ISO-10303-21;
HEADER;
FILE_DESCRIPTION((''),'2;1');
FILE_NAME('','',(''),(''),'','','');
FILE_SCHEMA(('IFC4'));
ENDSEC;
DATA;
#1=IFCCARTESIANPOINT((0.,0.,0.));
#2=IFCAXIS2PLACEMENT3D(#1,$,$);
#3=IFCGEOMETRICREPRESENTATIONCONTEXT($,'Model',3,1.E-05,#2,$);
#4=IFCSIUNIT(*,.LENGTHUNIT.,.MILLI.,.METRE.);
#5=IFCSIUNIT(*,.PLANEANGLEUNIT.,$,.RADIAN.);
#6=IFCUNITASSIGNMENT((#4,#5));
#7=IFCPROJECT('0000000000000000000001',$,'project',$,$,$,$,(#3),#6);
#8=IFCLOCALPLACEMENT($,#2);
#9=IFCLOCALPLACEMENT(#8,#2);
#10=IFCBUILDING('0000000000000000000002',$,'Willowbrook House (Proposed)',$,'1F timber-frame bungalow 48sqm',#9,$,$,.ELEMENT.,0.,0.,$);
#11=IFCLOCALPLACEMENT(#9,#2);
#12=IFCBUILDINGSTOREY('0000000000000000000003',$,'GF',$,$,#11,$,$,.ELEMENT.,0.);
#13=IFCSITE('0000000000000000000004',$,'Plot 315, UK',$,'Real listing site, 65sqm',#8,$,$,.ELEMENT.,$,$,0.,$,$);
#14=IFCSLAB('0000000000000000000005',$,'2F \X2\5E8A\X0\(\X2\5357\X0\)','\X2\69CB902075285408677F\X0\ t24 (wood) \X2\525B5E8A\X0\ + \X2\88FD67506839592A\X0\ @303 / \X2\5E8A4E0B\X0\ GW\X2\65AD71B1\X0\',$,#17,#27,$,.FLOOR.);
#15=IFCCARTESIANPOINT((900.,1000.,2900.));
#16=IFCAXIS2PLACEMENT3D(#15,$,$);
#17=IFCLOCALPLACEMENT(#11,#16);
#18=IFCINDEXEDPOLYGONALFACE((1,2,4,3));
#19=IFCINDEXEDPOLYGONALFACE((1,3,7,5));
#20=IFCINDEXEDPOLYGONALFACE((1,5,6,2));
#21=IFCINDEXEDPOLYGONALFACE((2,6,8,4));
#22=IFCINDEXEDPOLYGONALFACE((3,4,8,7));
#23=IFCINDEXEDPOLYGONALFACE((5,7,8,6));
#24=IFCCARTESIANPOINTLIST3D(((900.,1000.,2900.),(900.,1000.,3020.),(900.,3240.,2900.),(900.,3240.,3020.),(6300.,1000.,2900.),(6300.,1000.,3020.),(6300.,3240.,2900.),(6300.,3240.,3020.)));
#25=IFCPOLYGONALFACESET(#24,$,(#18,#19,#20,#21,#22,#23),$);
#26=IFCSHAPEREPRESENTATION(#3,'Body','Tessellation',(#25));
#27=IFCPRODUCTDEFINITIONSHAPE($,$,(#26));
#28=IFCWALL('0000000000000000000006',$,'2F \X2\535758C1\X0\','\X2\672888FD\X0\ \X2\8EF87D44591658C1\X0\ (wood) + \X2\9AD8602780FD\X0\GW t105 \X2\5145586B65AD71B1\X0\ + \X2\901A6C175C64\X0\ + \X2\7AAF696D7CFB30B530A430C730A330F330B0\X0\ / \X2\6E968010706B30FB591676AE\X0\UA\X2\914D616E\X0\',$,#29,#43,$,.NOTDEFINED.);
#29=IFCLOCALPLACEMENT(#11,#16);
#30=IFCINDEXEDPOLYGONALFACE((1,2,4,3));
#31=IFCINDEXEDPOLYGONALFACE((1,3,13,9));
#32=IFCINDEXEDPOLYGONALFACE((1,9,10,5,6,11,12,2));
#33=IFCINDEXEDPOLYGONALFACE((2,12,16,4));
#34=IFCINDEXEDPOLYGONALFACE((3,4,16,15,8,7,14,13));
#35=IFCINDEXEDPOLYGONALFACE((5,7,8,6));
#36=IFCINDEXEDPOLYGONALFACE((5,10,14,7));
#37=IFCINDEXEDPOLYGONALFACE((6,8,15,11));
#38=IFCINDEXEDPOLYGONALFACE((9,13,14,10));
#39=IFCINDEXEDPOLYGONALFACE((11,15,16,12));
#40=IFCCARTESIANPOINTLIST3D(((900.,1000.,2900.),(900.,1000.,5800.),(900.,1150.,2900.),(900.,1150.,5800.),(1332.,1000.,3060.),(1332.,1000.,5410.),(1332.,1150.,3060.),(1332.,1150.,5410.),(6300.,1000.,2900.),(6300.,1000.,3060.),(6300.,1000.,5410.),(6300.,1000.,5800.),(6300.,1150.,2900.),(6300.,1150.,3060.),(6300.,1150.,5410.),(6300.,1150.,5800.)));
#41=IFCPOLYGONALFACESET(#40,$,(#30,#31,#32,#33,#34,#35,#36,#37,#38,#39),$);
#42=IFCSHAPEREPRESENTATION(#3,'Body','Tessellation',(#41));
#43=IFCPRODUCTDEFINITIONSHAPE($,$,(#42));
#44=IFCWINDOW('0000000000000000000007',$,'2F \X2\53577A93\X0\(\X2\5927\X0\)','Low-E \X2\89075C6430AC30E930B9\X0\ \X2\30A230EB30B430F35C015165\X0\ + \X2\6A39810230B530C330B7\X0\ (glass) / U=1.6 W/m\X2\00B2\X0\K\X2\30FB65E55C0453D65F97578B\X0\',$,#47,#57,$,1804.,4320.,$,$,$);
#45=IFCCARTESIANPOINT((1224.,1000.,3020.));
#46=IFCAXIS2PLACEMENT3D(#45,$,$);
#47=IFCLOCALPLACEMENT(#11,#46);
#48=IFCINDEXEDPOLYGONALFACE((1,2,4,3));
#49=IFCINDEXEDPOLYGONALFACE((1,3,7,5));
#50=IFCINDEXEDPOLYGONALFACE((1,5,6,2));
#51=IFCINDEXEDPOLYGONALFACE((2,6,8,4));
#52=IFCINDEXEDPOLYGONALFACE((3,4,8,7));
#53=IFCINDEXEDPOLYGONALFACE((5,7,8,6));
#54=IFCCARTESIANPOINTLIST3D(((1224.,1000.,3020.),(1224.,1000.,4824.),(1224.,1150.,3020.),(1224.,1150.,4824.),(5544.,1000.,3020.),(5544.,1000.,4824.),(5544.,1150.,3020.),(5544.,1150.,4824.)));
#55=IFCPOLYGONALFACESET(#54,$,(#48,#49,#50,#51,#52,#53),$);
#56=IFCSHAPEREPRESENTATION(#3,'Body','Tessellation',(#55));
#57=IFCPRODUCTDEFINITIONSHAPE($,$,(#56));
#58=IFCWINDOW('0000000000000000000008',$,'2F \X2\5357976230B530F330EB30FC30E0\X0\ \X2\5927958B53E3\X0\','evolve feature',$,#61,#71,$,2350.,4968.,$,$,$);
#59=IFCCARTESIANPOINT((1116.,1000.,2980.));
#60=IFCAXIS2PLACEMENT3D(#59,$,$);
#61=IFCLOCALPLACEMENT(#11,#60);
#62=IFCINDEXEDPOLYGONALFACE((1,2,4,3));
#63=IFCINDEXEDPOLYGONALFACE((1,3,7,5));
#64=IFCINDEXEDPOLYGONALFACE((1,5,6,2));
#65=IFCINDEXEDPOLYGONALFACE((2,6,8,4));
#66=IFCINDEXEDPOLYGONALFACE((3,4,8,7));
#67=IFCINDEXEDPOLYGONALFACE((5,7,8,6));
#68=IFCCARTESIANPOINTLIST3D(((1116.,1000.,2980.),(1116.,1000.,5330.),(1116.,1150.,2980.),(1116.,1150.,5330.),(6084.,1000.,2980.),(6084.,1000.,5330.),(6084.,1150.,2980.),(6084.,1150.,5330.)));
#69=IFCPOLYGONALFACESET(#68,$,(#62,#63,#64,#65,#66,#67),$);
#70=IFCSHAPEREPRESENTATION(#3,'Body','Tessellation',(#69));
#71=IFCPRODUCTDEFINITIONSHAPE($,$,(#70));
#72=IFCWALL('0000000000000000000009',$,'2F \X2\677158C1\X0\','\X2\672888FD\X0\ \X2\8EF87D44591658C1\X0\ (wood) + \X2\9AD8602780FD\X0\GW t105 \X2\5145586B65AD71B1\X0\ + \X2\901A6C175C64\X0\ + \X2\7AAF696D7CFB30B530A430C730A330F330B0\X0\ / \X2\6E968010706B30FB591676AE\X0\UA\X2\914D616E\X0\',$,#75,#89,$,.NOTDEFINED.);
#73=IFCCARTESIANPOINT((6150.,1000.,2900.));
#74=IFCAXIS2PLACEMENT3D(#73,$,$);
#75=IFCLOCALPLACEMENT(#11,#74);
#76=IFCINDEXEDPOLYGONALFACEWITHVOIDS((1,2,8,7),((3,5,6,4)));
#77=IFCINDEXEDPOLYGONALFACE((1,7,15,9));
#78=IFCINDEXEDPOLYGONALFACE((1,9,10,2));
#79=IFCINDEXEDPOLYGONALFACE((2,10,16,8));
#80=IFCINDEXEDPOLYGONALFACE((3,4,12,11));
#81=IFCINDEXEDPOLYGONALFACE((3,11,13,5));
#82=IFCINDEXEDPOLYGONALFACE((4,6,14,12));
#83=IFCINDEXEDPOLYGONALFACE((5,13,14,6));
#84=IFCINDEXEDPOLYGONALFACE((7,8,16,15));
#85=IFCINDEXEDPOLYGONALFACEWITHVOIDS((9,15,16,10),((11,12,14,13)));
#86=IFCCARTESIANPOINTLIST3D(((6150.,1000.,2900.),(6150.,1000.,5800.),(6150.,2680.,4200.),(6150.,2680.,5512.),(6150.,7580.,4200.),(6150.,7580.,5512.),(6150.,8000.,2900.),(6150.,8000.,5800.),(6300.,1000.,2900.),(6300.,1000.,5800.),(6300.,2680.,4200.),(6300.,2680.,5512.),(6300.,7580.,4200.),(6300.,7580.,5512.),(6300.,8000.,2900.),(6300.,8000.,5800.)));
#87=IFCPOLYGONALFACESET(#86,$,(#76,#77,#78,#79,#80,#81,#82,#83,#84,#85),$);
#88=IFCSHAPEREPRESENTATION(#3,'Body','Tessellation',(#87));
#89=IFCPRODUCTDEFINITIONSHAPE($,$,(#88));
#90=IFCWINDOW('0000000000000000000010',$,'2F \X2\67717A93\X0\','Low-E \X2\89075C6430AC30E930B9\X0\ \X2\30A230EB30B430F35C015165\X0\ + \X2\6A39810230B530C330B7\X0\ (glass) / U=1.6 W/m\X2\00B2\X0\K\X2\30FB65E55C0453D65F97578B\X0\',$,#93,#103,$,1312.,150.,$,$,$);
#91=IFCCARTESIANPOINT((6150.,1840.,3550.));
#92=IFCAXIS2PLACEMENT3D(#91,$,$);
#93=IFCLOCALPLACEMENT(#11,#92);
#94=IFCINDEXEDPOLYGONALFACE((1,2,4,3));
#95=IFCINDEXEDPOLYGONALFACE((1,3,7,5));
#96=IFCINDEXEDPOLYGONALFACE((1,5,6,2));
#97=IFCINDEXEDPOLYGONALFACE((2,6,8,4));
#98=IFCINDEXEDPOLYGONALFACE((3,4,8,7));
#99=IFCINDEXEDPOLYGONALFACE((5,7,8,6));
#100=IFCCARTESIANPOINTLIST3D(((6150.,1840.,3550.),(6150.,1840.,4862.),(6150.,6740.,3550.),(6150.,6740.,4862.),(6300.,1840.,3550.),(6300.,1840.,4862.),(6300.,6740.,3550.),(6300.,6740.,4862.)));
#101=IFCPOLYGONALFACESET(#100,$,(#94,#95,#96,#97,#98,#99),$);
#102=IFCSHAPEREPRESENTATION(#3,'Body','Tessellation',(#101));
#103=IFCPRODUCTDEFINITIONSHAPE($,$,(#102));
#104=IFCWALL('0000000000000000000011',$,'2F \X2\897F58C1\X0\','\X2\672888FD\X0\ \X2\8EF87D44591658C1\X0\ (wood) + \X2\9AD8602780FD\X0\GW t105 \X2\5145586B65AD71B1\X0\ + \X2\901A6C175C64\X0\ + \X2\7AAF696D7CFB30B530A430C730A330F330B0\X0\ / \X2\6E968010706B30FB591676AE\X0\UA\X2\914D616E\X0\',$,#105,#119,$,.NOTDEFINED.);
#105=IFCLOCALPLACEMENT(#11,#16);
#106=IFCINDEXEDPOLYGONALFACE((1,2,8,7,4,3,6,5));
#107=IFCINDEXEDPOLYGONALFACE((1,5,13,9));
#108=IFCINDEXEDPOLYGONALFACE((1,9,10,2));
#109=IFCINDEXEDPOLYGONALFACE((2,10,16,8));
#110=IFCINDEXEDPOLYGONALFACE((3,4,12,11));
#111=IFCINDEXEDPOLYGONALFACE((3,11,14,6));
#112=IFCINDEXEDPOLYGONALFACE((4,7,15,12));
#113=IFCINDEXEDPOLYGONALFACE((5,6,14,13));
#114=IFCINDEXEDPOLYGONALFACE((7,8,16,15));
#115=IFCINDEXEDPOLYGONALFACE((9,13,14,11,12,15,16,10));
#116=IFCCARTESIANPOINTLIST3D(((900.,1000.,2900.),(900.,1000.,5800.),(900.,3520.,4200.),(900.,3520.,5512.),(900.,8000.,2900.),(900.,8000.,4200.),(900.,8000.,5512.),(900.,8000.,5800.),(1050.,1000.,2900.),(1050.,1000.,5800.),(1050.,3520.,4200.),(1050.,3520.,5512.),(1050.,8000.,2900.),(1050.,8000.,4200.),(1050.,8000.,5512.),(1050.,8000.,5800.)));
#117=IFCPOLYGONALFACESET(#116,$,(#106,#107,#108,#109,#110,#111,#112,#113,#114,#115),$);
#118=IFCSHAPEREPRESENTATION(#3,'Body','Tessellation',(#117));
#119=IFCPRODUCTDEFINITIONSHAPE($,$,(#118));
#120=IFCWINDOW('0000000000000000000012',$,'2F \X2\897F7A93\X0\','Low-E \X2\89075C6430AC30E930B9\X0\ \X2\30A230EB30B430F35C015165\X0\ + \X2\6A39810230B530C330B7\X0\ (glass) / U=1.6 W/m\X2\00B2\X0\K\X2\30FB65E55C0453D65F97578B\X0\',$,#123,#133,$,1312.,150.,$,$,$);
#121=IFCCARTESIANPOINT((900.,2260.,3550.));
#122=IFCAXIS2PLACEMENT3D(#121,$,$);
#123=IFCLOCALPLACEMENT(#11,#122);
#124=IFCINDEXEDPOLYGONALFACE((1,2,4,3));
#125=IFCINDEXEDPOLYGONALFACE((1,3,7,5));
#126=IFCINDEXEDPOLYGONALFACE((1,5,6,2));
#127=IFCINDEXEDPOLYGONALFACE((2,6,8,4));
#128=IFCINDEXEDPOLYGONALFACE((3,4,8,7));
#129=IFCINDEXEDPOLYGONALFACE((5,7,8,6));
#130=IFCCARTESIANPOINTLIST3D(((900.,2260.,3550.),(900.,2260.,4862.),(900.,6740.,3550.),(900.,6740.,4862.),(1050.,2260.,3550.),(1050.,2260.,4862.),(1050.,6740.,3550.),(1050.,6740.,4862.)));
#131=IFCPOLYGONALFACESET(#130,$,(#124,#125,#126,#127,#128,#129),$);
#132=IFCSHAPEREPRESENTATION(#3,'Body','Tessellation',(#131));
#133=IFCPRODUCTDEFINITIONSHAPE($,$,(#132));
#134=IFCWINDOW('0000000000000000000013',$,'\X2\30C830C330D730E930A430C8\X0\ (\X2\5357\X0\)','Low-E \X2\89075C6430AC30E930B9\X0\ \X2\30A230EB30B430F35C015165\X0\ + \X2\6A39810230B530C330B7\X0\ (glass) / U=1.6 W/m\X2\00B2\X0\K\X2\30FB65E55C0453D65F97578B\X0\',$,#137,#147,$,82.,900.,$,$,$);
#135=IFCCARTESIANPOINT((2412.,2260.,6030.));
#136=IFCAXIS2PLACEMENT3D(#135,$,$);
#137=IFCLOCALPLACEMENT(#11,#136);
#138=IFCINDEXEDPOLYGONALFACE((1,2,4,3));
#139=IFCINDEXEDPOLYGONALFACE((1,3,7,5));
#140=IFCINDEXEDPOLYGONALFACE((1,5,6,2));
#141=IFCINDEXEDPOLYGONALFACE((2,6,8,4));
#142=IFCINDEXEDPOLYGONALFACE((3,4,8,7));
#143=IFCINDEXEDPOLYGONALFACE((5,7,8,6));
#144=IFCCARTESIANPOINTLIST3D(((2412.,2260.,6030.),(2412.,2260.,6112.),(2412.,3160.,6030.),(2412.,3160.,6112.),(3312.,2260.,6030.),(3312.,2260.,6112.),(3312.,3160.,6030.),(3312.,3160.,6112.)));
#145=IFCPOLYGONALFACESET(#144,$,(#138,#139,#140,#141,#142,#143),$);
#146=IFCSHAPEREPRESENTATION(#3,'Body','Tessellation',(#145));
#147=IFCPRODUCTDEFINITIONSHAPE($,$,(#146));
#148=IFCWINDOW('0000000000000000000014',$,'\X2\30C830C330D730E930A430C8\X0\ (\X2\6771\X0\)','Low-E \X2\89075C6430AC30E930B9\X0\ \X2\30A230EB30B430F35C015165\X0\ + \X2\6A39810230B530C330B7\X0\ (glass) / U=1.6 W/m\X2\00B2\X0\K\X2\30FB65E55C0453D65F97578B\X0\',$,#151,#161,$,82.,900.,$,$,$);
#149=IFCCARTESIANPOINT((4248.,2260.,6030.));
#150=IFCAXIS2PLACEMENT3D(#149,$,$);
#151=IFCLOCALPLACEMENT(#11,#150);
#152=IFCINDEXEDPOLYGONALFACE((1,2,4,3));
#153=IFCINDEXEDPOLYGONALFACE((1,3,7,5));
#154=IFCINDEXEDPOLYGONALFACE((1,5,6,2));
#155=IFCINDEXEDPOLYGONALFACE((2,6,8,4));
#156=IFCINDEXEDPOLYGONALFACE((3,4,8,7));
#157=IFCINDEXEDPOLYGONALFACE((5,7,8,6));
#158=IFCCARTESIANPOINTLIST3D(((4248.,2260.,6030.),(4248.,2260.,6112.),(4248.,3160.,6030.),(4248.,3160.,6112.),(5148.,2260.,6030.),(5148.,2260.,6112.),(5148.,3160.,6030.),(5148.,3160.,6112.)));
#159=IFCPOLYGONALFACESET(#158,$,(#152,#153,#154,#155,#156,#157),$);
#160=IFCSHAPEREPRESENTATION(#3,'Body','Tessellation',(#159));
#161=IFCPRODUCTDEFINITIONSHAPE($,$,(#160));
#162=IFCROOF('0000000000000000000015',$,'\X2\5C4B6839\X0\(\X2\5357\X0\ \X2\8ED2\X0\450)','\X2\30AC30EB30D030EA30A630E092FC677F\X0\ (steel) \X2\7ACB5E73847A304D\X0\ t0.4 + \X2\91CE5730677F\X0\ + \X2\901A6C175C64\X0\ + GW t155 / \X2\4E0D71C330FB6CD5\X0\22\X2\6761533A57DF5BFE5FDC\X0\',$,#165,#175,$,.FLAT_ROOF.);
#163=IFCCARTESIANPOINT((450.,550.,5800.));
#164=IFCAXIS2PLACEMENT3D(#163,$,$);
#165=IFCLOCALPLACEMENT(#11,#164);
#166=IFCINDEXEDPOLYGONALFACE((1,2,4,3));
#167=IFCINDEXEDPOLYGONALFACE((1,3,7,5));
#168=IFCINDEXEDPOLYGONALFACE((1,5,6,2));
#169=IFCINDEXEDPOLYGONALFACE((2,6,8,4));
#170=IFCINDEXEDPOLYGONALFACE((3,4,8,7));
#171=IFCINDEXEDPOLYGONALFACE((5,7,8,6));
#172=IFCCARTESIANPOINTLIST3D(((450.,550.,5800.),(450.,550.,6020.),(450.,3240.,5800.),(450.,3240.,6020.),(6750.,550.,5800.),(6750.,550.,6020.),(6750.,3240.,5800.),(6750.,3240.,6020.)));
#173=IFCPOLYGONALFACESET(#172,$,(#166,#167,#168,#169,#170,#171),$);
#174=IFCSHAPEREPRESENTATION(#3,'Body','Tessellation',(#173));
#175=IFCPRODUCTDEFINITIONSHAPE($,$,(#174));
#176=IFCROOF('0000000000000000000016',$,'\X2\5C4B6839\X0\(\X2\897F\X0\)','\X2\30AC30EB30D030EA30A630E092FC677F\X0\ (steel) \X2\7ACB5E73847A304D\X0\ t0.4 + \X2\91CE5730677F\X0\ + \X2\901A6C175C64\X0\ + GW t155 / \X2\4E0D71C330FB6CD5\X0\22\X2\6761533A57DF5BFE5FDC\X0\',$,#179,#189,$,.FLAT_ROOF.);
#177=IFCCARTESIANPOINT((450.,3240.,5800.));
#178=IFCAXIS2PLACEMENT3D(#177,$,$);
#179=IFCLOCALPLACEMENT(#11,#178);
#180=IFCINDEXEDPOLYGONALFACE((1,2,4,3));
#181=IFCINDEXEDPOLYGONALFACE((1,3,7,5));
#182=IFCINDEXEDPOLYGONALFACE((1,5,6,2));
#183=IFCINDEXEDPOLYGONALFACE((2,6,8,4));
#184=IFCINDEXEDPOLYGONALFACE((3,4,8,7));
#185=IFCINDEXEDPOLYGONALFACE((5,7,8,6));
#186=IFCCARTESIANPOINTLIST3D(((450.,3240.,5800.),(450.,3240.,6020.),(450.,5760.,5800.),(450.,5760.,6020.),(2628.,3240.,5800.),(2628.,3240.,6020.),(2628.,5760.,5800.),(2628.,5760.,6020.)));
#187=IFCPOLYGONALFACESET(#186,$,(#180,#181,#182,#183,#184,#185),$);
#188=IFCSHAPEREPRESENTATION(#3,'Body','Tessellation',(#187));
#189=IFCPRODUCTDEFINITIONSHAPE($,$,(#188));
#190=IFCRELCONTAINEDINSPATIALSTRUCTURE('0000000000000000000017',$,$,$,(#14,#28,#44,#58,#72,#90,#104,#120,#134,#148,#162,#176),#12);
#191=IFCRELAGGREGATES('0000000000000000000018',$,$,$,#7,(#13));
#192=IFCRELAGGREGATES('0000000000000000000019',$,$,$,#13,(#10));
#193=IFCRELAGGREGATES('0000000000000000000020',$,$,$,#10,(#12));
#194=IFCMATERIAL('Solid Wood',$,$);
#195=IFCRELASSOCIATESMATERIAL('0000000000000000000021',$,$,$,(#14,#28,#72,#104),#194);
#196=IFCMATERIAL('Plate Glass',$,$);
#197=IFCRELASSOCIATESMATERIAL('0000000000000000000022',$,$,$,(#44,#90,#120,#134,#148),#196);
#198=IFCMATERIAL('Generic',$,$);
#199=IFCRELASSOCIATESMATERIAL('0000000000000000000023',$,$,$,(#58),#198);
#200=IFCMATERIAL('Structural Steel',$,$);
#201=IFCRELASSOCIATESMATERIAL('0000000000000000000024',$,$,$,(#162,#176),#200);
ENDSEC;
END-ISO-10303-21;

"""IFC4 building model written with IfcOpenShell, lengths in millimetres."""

from ifc_helpers import new_model, si_unit, frame, frame_2d, origin, place, context, project, spatial, rectangle, extrude, material, element, fill, save


model = new_model("IFC4")

# Units and contexts
model_context = context("Model", 3, precision=1e-05, world=origin())
ifc_project = project(units=[si_unit("LENGTHUNIT", "METRE", prefix="MILLI"), si_unit("PLANEANGLEUNIT", "RADIAN")], contexts=[model_context])

# Site, building, storey
site_placement = place(None, origin())
site = spatial("IfcSite", under=ifc_project, at=site_placement, Name="Plot 315, UK", ObjectType="Real listing site, 65sqm", CompositionType="ELEMENT", RefElevation=0.0)
building_placement = place(site_placement, origin())
building = spatial("IfcBuilding", under=site, at=building_placement, Name="Willowbrook House (Proposed)", ObjectType="1F timber-frame bungalow 48sqm", CompositionType="ELEMENT", ElevationOfRefHeight=0.0, ElevationOfTerrain=0.0)
storey_placement = place(building_placement, origin())
storey = spatial("IfcBuildingStorey", under=building, at=storey_placement, Name="GF", CompositionType="ELEMENT", Elevation=0.0)

# Slab
ifc_material_1 = material(Name="Solid Wood")
slab_placement = place(storey_placement, frame((900.0, 1000.0, 2900.0)))
element("IfcSlab", 1, at=slab_placement, inside=storey, material=ifc_material_1, Name="2F 床(南)", Description="構造用合板 t24 (wood) 剛床 + 製材根太 @303 / 床下 GW断熱", PredefinedType="FLOOR", context=model_context, shape_type="SweptSolid", body=[
    extrude(rectangle(XDim=5400.0, YDim=2240.0, at=frame_2d((2700.0, 1120.0))), frame((900.0, 1000.0, 2900.0)), (0.0, 0.0, 1.0), 120.0),
])

# Wall, openings, windows
wall_1_placement = place(storey_placement, frame((900.0, 1000.0, 2900.0)))
wall_1 = element("IfcWall", 2, at=wall_1_placement, inside=storey, material=ifc_material_1, Name="2F 南壁", Description="木製 軸組外壁 (wood) + 高性能GW t105 充填断熱 + 通気層 + 窯業系サイディング / 準耐火・外皮UA配慮", PredefinedType="NOTDEFINED", context=model_context, shape_type="SweptSolid", body=[
    extrude(rectangle(XDim=5400.0, YDim=150.0, at=frame_2d((2700.0, 75.0))), frame((900.0, 1000.0, 2900.0)), (0.0, 0.0, 1.0), 2900.0),
])
opening_1_placement = place(storey_placement, frame((1224.0, 1000.0, 3020.0)))
opening_1 = element("IfcOpeningElement", 3, at=opening_1_placement, cuts=wall_1, PredefinedType="NOTDEFINED", context=model_context, shape_type="SweptSolid", body=[
    extrude(rectangle(XDim=4320.0, YDim=150.0, at=frame_2d((2160.0, 75.0))), frame((1224.0, 1000.0, 3020.0)), (0.0, 0.0, 1.0), 1804.0),
])
opening_2_placement = place(storey_placement, frame((1116.0, 1000.0, 2980.0)))
opening_2 = element("IfcOpeningElement", 4, at=opening_2_placement, cuts=wall_1, PredefinedType="NOTDEFINED", context=model_context, shape_type="SweptSolid", body=[
    extrude(rectangle(XDim=4968.0, YDim=150.0, at=frame_2d((2484.0, 75.0))), frame((1116.0, 1000.0, 2980.0)), (0.0, 0.0, 1.0), 2350.0),
])
ifc_material_2 = material(Name="Plate Glass")
window_1_placement = place(storey_placement, frame((1224.0, 1000.0, 3020.0)))
window_1 = element("IfcWindow", 5, at=window_1_placement, inside=storey, material=ifc_material_2, Name="2F 南窓(大)", Description="Low-E 複層ガラス アルゴン封入 + 樹脂サッシ (glass) / U=1.6 W/m²K・日射取得型", OverallHeight=1804.0, OverallWidth=4320.0, context=model_context, shape_type="SweptSolid", body=[
    extrude(rectangle(XDim=4320.0, YDim=150.0, at=frame_2d((2160.0, 75.0))), frame((1224.0, 1000.0, 3020.0)), (0.0, 0.0, 1.0), 1804.0),
])
fill(opening_1, window_1)
ifc_material_3 = material(Name="Generic")
window_2_placement = place(storey_placement, frame((1116.0, 1000.0, 2980.0)))
window_2 = element("IfcWindow", 6, at=window_2_placement, inside=storey, material=ifc_material_3, Name="2F 南面サンルーム 大開口", Description="evolve feature", OverallHeight=2350.0, OverallWidth=4968.0, context=model_context, shape_type="SweptSolid", body=[
    extrude(rectangle(XDim=4968.0, YDim=150.0, at=frame_2d((2484.0, 75.0))), frame((1116.0, 1000.0, 2980.0)), (0.0, 0.0, 1.0), 2350.0),
])
fill(opening_2, window_2)

# Walls, openings, windows
wall_2_placement = place(storey_placement, frame((6150.0, 1000.0, 2900.0)))
wall_2 = element("IfcWall", 7, at=wall_2_placement, inside=storey, material=ifc_material_1, Name="2F 東壁", Description="木製 軸組外壁 (wood) + 高性能GW t105 充填断熱 + 通気層 + 窯業系サイディング / 準耐火・外皮UA配慮", PredefinedType="NOTDEFINED", context=model_context, shape_type="SweptSolid", body=[
    extrude(rectangle(XDim=150.0, YDim=7000.0, at=frame_2d((75.0, 3500.0))), frame((6150.0, 1000.0, 2900.0)), (0.0, 0.0, 1.0), 2900.0),
])
opening_3_placement = place(storey_placement, frame((6150.0, 1840.0, 3550.0)))
opening_3 = element("IfcOpeningElement", 8, at=opening_3_placement, cuts=wall_2, PredefinedType="NOTDEFINED", context=model_context, shape_type="SweptSolid", body=[
    extrude(rectangle(XDim=150.0, YDim=4900.0, at=frame_2d((75.0, 2450.0))), frame((6150.0, 1840.0, 3550.0)), (0.0, 0.0, 1.0), 1312.0),
])
window_3_placement = place(storey_placement, frame((6150.0, 1840.0, 3550.0)))
window_3 = element("IfcWindow", 9, at=window_3_placement, inside=storey, material=ifc_material_2, Name="2F 東窓", Description="Low-E 複層ガラス アルゴン封入 + 樹脂サッシ (glass) / U=1.6 W/m²K・日射取得型", OverallHeight=1312.0, OverallWidth=150.0, context=model_context, shape_type="SweptSolid", body=[
    extrude(rectangle(XDim=150.0, YDim=4900.0, at=frame_2d((75.0, 2450.0))), frame((6150.0, 1840.0, 3550.0)), (0.0, 0.0, 1.0), 1312.0),
])
fill(opening_3, window_3)
wall_3_placement = place(storey_placement, frame((900.0, 1000.0, 2900.0)))
wall_3 = element("IfcWall", 10, at=wall_3_placement, inside=storey, material=ifc_material_1, Name="2F 西壁", Description="木製 軸組外壁 (wood) + 高性能GW t105 充填断熱 + 通気層 + 窯業系サイディング / 準耐火・外皮UA配慮", PredefinedType="NOTDEFINED", context=model_context, shape_type="SweptSolid", body=[
    extrude(rectangle(XDim=150.0, YDim=7000.0, at=frame_2d((75.0, 3500.0))), frame((900.0, 1000.0, 2900.0)), (0.0, 0.0, 1.0), 2900.0),
])
opening_4_placement = place(storey_placement, frame((900.0, 2260.0, 3550.0)))
opening_4 = element("IfcOpeningElement", 11, at=opening_4_placement, cuts=wall_3, PredefinedType="NOTDEFINED", context=model_context, shape_type="SweptSolid", body=[
    extrude(rectangle(XDim=150.0, YDim=4480.0, at=frame_2d((75.0, 2240.0))), frame((900.0, 2260.0, 3550.0)), (0.0, 0.0, 1.0), 1312.0),
])
window_4_placement = place(storey_placement, frame((900.0, 2260.0, 3550.0)))
window_4 = element("IfcWindow", 12, at=window_4_placement, inside=storey, material=ifc_material_2, Name="2F 西窓", Description="Low-E 複層ガラス アルゴン封入 + 樹脂サッシ (glass) / U=1.6 W/m²K・日射取得型", OverallHeight=1312.0, OverallWidth=150.0, context=model_context, shape_type="SweptSolid", body=[
    extrude(rectangle(XDim=150.0, YDim=4480.0, at=frame_2d((75.0, 2240.0))), frame((900.0, 2260.0, 3550.0)), (0.0, 0.0, 1.0), 1312.0),
])
fill(opening_4, window_4)

# Windows
window_5_placement = place(storey_placement, frame((2412.0, 2260.0, 6030.0)))
element("IfcWindow", 13, at=window_5_placement, inside=storey, material=ifc_material_2, Name="トップライト (南)", Description="Low-E 複層ガラス アルゴン封入 + 樹脂サッシ (glass) / U=1.6 W/m²K・日射取得型", OverallHeight=82.0, OverallWidth=900.0, context=model_context, shape_type="SweptSolid", body=[
    extrude(rectangle(XDim=900.0, YDim=900.0, at=frame_2d((450.0, 450.0))), frame((2412.0, 2260.0, 6030.0)), (0.0, 0.0, 1.0), 82.0),
])
window_6_placement = place(storey_placement, frame((4248.0, 2260.0, 6030.0)))
element("IfcWindow", 14, at=window_6_placement, inside=storey, material=ifc_material_2, Name="トップライト (東)", Description="Low-E 複層ガラス アルゴン封入 + 樹脂サッシ (glass) / U=1.6 W/m²K・日射取得型", OverallHeight=82.0, OverallWidth=900.0, context=model_context, shape_type="SweptSolid", body=[
    extrude(rectangle(XDim=900.0, YDim=900.0, at=frame_2d((450.0, 450.0))), frame((4248.0, 2260.0, 6030.0)), (0.0, 0.0, 1.0), 82.0),
])

# Roofs
ifc_material_4 = material(Name="Structural Steel")
roof_1_placement = place(storey_placement, frame((450.0, 550.0, 5800.0)))
element("IfcRoof", 15, at=roof_1_placement, inside=storey, material=ifc_material_4, Name="屋根(南 軒450)", Description="ガルバリウム鋼板 (steel) 立平葺き t0.4 + 野地板 + 通気層 + GW t155 / 不燃・法22条区域対応", PredefinedType="FLAT_ROOF", context=model_context, shape_type="SweptSolid", body=[
    extrude(rectangle(XDim=6300.0, YDim=2690.0, at=frame_2d((3150.0, 1345.0))), frame((450.0, 550.0, 5800.0)), (0.0, 0.0, 1.0), 220.0),
])
roof_2_placement = place(storey_placement, frame((450.0, 3240.0, 5800.0)))
element("IfcRoof", 16, at=roof_2_placement, inside=storey, material=ifc_material_4, Name="屋根(西)", Description="ガルバリウム鋼板 (steel) 立平葺き t0.4 + 野地板 + 通気層 + GW t155 / 不燃・法22条区域対応", PredefinedType="FLAT_ROOF", context=model_context, shape_type="SweptSolid", body=[
    extrude(rectangle(XDim=2178.0, YDim=2520.0, at=frame_2d((1089.0, 1260.0))), frame((450.0, 3240.0, 5800.0)), (0.0, 0.0, 1.0), 220.0),
])

save(model, "model.ifc")
